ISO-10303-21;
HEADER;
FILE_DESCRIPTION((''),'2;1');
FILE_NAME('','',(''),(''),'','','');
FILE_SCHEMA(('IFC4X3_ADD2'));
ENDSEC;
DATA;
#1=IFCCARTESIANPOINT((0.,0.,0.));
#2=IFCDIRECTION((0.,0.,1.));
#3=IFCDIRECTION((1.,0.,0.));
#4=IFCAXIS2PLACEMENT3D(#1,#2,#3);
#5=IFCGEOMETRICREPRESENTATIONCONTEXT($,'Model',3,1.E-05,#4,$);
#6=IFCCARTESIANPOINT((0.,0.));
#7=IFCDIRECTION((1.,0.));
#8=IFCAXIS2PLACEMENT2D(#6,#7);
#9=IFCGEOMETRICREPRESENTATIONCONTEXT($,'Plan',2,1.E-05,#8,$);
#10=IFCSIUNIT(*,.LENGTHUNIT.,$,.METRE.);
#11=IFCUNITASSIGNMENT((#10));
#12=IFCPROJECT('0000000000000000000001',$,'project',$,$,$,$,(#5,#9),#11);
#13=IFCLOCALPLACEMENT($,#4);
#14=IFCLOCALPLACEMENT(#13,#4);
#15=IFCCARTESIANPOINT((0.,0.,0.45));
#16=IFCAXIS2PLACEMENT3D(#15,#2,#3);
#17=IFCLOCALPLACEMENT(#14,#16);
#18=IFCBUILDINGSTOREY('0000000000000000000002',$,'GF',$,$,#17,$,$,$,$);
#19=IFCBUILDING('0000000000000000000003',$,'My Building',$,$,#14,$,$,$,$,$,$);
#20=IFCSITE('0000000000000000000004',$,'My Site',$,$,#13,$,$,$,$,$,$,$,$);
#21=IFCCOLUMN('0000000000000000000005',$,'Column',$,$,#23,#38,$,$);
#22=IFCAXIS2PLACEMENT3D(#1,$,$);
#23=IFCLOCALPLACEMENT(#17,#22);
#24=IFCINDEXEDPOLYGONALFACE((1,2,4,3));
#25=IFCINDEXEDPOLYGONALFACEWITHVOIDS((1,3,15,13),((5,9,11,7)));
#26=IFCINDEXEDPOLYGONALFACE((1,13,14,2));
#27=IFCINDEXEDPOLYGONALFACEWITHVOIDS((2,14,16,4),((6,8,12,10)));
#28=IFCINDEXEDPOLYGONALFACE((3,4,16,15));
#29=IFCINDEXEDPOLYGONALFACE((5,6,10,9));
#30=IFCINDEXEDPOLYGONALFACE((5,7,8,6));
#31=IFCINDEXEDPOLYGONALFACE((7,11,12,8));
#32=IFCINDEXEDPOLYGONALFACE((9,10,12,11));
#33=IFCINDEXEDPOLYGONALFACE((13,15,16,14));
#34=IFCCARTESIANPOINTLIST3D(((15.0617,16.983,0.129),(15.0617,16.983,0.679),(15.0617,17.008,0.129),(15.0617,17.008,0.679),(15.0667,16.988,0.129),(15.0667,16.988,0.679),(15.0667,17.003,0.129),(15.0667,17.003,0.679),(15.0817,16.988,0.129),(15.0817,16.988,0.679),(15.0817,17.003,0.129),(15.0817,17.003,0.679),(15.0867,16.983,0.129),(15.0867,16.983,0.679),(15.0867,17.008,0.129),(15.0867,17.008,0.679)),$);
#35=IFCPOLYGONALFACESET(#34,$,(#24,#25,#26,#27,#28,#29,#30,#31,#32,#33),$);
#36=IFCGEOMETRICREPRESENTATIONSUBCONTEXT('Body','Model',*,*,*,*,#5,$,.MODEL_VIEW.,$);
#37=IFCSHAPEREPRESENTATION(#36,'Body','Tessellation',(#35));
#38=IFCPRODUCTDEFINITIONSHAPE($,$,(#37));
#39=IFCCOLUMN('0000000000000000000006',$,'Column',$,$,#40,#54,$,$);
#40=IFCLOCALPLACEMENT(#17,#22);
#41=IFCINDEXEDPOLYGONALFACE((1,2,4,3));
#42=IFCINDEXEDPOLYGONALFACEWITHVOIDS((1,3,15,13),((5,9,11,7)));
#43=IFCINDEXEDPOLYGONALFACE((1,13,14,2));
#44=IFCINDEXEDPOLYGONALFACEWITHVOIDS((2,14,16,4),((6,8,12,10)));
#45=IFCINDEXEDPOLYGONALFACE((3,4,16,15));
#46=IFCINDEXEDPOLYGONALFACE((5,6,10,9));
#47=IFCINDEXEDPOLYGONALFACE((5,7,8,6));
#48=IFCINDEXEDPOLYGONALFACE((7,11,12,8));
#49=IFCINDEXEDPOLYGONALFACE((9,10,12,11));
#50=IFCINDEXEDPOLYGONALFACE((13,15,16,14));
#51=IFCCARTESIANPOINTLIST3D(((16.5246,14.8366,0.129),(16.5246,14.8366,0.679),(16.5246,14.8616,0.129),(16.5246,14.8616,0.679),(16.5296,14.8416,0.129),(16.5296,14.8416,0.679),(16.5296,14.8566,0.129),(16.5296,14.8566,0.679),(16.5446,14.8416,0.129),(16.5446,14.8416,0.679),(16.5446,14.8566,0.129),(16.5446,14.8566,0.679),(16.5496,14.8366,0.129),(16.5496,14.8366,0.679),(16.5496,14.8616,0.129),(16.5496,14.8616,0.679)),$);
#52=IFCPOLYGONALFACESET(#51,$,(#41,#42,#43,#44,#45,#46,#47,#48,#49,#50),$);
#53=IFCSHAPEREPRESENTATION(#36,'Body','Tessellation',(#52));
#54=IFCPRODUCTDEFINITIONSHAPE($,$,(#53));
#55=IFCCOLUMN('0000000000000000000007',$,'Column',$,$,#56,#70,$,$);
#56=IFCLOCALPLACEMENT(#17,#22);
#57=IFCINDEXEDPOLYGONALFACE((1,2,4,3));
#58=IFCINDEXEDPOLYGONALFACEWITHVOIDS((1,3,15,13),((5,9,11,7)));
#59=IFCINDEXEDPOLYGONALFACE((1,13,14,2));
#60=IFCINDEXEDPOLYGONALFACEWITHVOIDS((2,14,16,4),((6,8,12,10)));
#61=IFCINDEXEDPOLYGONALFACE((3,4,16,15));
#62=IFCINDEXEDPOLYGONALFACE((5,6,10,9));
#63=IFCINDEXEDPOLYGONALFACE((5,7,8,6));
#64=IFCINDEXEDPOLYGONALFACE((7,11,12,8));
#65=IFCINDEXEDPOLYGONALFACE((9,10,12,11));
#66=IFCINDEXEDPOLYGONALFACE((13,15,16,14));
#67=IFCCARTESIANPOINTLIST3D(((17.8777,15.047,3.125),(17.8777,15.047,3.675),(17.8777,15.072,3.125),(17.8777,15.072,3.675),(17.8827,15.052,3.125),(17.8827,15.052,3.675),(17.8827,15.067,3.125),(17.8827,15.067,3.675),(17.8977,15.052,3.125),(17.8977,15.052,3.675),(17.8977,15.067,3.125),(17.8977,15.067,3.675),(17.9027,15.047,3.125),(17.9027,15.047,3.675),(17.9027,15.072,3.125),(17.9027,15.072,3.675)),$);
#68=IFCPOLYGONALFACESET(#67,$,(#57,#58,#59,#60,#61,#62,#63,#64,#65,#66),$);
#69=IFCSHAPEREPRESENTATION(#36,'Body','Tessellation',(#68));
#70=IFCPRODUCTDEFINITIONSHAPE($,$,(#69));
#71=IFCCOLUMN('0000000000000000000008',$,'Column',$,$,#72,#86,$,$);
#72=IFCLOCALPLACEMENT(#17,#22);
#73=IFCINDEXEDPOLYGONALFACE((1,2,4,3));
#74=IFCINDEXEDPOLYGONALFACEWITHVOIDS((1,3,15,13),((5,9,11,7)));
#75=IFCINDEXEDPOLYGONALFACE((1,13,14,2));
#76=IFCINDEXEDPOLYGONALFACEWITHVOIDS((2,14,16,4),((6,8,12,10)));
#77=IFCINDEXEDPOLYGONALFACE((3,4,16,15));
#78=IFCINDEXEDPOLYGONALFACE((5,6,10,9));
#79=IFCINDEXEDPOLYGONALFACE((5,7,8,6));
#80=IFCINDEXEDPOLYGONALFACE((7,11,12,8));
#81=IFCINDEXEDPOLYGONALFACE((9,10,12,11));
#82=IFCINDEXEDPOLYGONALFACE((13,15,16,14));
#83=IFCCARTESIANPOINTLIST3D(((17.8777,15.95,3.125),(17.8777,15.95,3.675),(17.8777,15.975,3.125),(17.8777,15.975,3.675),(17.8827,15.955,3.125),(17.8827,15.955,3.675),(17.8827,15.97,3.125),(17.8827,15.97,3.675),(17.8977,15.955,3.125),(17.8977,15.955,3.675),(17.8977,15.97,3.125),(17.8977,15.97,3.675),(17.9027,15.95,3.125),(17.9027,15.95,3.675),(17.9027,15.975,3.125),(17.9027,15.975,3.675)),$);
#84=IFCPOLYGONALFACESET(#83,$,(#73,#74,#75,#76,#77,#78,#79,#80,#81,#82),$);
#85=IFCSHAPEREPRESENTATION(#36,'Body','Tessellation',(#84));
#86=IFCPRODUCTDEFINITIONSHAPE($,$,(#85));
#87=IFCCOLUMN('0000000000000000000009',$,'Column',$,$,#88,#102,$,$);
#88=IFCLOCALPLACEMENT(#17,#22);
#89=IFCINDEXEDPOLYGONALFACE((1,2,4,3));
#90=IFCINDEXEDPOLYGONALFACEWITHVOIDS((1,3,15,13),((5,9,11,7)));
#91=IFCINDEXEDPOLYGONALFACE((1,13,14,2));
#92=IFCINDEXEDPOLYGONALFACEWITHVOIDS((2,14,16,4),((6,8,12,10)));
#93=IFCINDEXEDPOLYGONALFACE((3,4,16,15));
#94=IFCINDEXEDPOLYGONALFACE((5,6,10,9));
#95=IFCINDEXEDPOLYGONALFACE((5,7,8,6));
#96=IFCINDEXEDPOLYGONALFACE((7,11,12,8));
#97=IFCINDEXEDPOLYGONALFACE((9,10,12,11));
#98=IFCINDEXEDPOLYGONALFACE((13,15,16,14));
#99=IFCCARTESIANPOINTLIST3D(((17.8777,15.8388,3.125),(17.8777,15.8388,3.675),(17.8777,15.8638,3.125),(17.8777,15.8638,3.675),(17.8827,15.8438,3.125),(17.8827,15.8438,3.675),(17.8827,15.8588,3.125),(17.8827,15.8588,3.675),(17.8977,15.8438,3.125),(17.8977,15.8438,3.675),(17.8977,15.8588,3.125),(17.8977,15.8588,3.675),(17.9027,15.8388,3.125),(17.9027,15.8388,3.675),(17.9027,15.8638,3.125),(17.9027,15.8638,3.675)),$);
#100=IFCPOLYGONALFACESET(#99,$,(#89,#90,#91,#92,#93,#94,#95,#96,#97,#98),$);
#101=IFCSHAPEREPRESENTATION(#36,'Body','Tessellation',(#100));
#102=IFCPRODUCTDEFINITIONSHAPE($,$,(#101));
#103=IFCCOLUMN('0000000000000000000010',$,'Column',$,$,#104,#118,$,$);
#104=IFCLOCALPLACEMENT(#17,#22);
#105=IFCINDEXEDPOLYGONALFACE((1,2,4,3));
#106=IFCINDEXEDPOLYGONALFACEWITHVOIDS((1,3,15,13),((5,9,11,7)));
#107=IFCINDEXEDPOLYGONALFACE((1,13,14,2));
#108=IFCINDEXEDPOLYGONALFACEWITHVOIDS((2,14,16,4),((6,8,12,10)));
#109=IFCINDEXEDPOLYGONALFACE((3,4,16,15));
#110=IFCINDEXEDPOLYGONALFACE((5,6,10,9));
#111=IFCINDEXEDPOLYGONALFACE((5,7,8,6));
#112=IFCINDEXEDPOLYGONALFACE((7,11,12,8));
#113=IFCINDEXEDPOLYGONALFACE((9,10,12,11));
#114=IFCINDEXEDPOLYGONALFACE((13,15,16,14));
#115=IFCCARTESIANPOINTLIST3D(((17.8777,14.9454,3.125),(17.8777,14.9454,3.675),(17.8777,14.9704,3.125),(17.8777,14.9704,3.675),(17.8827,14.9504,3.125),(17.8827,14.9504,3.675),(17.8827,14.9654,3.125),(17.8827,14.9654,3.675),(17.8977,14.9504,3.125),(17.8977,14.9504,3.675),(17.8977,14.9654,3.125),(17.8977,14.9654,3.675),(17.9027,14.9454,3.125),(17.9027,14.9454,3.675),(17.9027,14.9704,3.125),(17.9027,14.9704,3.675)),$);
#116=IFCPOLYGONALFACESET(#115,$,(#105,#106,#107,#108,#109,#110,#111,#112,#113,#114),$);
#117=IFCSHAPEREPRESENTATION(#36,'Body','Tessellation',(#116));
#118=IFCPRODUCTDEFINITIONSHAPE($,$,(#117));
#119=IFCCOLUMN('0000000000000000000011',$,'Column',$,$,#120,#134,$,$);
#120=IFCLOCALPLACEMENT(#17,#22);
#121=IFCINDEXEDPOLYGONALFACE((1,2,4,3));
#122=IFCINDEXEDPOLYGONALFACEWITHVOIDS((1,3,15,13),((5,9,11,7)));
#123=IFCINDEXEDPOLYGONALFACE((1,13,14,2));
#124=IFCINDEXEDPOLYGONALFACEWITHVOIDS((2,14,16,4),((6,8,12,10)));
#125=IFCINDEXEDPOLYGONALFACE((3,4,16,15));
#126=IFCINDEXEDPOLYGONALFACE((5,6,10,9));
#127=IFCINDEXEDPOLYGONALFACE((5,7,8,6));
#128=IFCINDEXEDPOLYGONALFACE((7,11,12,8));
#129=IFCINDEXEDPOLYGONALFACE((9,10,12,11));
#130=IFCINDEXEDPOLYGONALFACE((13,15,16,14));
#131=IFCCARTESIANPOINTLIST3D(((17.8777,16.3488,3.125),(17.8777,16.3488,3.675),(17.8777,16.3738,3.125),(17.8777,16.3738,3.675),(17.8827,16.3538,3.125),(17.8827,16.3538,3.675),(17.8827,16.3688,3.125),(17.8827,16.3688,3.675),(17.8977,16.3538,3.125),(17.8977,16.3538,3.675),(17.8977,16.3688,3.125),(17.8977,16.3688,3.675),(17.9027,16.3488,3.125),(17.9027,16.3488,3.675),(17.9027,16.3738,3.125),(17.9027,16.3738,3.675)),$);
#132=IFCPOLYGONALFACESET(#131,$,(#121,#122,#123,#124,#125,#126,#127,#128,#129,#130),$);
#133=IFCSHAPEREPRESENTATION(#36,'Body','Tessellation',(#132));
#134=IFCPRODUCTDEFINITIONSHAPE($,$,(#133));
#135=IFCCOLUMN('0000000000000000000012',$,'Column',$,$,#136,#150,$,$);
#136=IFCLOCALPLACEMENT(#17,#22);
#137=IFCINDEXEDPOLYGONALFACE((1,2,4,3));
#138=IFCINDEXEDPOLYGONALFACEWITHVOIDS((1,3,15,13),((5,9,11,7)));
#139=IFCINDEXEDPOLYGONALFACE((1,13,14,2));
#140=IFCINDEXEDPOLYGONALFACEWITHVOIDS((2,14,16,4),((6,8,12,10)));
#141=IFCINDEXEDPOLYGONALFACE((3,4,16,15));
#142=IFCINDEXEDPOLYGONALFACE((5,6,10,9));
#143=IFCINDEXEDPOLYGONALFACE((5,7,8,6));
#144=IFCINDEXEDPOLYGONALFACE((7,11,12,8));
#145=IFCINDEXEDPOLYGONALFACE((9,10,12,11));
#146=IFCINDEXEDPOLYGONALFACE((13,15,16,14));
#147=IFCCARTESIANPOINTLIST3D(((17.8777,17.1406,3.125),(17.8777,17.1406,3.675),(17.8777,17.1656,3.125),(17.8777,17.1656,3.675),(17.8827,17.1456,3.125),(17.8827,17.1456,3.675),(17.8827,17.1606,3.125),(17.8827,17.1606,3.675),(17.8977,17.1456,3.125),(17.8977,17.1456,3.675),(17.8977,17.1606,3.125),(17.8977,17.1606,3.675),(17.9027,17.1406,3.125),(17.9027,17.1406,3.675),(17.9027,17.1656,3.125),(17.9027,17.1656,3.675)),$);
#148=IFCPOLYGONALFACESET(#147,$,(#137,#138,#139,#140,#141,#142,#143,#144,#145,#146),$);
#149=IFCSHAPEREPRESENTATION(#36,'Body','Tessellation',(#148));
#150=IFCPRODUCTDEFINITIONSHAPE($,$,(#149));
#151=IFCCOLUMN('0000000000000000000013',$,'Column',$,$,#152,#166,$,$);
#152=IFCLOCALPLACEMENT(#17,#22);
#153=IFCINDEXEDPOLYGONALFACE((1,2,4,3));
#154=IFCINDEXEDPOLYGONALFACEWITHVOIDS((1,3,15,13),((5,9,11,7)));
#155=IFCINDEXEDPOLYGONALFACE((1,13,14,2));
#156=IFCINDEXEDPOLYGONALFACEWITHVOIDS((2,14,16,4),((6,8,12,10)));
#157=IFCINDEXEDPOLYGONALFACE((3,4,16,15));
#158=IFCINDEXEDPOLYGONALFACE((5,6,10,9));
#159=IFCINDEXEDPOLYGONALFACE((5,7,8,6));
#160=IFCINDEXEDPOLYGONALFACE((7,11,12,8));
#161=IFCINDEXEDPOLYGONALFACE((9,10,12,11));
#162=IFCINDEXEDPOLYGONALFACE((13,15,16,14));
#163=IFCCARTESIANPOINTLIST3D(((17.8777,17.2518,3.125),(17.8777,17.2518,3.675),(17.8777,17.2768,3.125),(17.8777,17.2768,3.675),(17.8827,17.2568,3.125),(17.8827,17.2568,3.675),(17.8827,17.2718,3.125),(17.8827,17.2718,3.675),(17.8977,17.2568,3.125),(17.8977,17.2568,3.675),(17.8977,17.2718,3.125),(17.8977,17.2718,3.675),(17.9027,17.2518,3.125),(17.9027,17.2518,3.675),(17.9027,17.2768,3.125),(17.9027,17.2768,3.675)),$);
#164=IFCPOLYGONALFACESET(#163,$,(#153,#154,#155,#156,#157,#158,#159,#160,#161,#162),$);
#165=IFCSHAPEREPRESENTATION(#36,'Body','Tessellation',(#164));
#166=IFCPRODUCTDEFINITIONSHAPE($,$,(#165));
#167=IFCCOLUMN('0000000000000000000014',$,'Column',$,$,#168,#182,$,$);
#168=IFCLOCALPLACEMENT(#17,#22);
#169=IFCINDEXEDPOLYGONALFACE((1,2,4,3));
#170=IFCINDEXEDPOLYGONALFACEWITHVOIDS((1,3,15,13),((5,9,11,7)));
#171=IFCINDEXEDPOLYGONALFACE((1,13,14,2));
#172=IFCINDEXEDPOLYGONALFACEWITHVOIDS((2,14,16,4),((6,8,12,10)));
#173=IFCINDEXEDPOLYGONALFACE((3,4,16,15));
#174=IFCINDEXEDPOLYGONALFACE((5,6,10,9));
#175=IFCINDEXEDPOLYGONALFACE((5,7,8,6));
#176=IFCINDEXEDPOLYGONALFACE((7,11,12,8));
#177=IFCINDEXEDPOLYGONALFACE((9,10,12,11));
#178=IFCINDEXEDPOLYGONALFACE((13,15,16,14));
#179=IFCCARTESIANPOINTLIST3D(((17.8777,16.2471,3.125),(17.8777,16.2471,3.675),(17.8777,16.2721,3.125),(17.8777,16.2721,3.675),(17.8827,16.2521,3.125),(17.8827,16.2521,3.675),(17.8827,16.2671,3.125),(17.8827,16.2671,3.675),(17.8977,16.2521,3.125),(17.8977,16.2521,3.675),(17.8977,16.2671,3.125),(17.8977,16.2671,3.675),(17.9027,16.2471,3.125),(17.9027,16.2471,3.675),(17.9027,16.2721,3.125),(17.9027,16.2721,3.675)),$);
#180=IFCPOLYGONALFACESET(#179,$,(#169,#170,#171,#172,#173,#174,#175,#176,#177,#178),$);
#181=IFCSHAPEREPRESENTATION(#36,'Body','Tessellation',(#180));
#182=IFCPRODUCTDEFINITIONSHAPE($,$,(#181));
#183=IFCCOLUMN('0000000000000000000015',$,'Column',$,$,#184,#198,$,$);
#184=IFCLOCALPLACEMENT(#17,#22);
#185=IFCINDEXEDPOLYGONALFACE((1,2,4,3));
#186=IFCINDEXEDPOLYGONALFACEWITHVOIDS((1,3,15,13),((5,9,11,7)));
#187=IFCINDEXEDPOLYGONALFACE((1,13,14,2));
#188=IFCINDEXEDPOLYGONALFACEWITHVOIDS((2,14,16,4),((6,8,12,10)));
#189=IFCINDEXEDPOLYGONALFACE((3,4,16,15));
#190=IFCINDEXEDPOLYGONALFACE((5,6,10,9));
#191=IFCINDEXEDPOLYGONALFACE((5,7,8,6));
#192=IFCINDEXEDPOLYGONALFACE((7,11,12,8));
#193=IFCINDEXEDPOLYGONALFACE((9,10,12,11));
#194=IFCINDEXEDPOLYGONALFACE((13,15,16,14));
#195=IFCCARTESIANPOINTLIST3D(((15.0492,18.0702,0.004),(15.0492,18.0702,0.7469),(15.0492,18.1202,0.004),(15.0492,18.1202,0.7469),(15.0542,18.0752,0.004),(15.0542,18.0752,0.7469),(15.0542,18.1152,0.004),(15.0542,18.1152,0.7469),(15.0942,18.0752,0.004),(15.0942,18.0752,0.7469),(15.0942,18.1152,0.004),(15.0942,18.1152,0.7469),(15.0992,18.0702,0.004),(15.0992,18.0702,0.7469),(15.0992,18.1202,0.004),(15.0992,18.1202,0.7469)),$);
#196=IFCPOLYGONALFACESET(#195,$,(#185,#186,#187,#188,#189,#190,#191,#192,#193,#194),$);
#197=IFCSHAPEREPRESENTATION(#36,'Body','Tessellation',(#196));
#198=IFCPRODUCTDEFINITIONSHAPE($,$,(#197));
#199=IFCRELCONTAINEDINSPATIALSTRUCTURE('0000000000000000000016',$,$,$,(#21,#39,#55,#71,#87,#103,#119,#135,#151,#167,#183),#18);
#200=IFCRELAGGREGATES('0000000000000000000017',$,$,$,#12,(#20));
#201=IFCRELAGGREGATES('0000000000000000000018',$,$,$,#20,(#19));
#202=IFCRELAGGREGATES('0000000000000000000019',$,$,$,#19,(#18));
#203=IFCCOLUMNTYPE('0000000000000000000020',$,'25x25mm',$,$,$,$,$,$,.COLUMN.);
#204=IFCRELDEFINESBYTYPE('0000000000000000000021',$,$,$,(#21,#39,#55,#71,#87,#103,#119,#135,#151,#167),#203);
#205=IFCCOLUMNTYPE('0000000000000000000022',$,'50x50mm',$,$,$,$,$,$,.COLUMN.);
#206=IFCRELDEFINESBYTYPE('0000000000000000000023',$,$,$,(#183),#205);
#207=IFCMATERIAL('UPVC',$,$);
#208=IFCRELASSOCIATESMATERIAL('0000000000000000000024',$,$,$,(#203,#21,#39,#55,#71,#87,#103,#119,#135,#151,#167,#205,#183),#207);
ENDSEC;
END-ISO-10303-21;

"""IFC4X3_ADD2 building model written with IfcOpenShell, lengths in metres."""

from ifc_helpers import new_model, si_unit, frame, origin_with_axes, origin_2d_with_axis, place, context, subcontext, project, spatial, hollow_rectangle, extrude, material, material_profile, profile_set, profile_usage, type_object, element, save


model = new_model("IFC4X3_ADD2")

# Units and contexts
model_context = context("Model", 3, precision=1e-05, world=origin_with_axes())
plan_context = context("Plan", 2, precision=1e-05, world=origin_2d_with_axis())
body_context_1 = subcontext(model_context, "Body", "Model", "MODEL_VIEW")
ifc_project = project(units=[si_unit("LENGTHUNIT", "METRE")], contexts=[model_context, plan_context])

# Site, building, storey
site_placement = place(None, origin_with_axes())
site = spatial("IfcSite", under=ifc_project, at=site_placement, Name="My Site")
building_placement = place(site_placement, origin_with_axes())
building = spatial("IfcBuilding", under=site, at=building_placement, Name="My Building")
storey_placement = place(building_placement, frame((0.0, 0.0, 0.45), z_axis=(0.0, 0.0, 1.0), x_axis=(1.0, 0.0, 0.0)))
storey = spatial("IfcBuildingStorey", under=building, at=storey_placement, Name="GF")

# Columns
ifc_material_1 = material(Name="UPVC")
ifc_material_profile_1 = material_profile(ifc_material_1, hollow_rectangle(XDim=0.025, YDim=0.025, WallThickness=0.005))
ifc_profile_set_1 = profile_set([ifc_material_profile_1])
column_type_1 = type_object("IfcColumnType", Name="25x25mm", PredefinedType="COLUMN", material=ifc_profile_set_1)
ifc_profile_usage_1 = profile_usage(ifc_profile_set_1)
column_1_placement = place(storey_placement, frame((15.0742, 16.9955, 0.129), z_axis=(0.0, 0.0, 1.0), x_axis=(0.0, -1.0, 0.0)))
element("IfcColumn", 1, at=column_1_placement, inside=storey, type_object=column_type_1, material=ifc_profile_usage_1, Name="Column", context=body_context_1, shape_type="SweptSolid", body=[
    extrude(hollow_rectangle(XDim=0.025, YDim=0.025, WallThickness=0.005), origin_with_axes(), (0.0, 0.0, 1.0), 0.55),
])
ifc_profile_usage_2 = profile_usage(ifc_profile_set_1)
column_2_placement = place(storey_placement, frame((16.5371, 14.8491, 0.129), z_axis=(0.0, 0.0, 1.0), x_axis=(0.0, -1.0, 0.0)))
element("IfcColumn", 2, at=column_2_placement, inside=storey, type_object=column_type_1, material=ifc_profile_usage_2, Name="Column", context=body_context_1, shape_type="SweptSolid", body=[
    extrude(hollow_rectangle(XDim=0.025, YDim=0.025, WallThickness=0.005), origin_with_axes(), (0.0, 0.0, 1.0), 0.55),
])
ifc_profile_usage_3 = profile_usage(ifc_profile_set_1)
column_3_placement = place(storey_placement, frame((17.8902, 15.0595, 3.125), z_axis=(0.0, 0.0, 1.0), x_axis=(0.0, -1.0, 0.0)))
element("IfcColumn", 3, at=column_3_placement, inside=storey, type_object=column_type_1, material=ifc_profile_usage_3, Name="Column", context=body_context_1, shape_type="SweptSolid", body=[
    extrude(hollow_rectangle(XDim=0.025, YDim=0.025, WallThickness=0.005), origin_with_axes(), (0.0, 0.0, 1.0), 0.55),
])
ifc_profile_usage_4 = profile_usage(ifc_profile_set_1)
column_4_placement = place(storey_placement, frame((17.8902, 15.9625, 3.125), z_axis=(0.0, 0.0, 1.0), x_axis=(0.0, -1.0, 0.0)))
element("IfcColumn", 4, at=column_4_placement, inside=storey, type_object=column_type_1, material=ifc_profile_usage_4, Name="Column", context=body_context_1, shape_type="SweptSolid", body=[
    extrude(hollow_rectangle(XDim=0.025, YDim=0.025, WallThickness=0.005), origin_with_axes(), (0.0, 0.0, 1.0), 0.55),
])
ifc_profile_usage_5 = profile_usage(ifc_profile_set_1)
column_5_placement = place(storey_placement, frame((17.8902, 15.8513, 3.125), z_axis=(0.0, 0.0, 1.0), x_axis=(0.0, -1.0, 0.0)))
element("IfcColumn", 5, at=column_5_placement, inside=storey, type_object=column_type_1, material=ifc_profile_usage_5, Name="Column", context=body_context_1, shape_type="SweptSolid", body=[
    extrude(hollow_rectangle(XDim=0.025, YDim=0.025, WallThickness=0.005), origin_with_axes(), (0.0, 0.0, 1.0), 0.55),
])
ifc_profile_usage_6 = profile_usage(ifc_profile_set_1)
column_6_placement = place(storey_placement, frame((17.8902, 14.9579, 3.125), z_axis=(0.0, 0.0, 1.0), x_axis=(0.0, -1.0, 0.0)))
element("IfcColumn", 6, at=column_6_placement, inside=storey, type_object=column_type_1, material=ifc_profile_usage_6, Name="Column", context=body_context_1, shape_type="SweptSolid", body=[
    extrude(hollow_rectangle(XDim=0.025, YDim=0.025, WallThickness=0.005), origin_with_axes(), (0.0, 0.0, 1.0), 0.55),
])
ifc_profile_usage_7 = profile_usage(ifc_profile_set_1)
column_7_placement = place(storey_placement, frame((17.8902, 16.3613, 3.125), z_axis=(0.0, 0.0, 1.0), x_axis=(0.0, -1.0, 0.0)))
element("IfcColumn", 7, at=column_7_placement, inside=storey, type_object=column_type_1, material=ifc_profile_usage_7, Name="Column", context=body_context_1, shape_type="SweptSolid", body=[
    extrude(hollow_rectangle(XDim=0.025, YDim=0.025, WallThickness=0.005), origin_with_axes(), (0.0, 0.0, 1.0), 0.55),
])
ifc_profile_usage_8 = profile_usage(ifc_profile_set_1)
column_8_placement = place(storey_placement, frame((17.8902, 17.1531, 3.125), z_axis=(0.0, 0.0, 1.0), x_axis=(0.0, -1.0, 0.0)))
element("IfcColumn", 8, at=column_8_placement, inside=storey, type_object=column_type_1, material=ifc_profile_usage_8, Name="Column", context=body_context_1, shape_type="SweptSolid", body=[
    extrude(hollow_rectangle(XDim=0.025, YDim=0.025, WallThickness=0.005), origin_with_axes(), (0.0, 0.0, 1.0), 0.55),
])
ifc_profile_usage_9 = profile_usage(ifc_profile_set_1)
column_9_placement = place(storey_placement, frame((17.8902, 17.2643, 3.125), z_axis=(0.0, 0.0, 1.0), x_axis=(0.0, -1.0, 0.0)))
element("IfcColumn", 9, at=column_9_placement, inside=storey, type_object=column_type_1, material=ifc_profile_usage_9, Name="Column", context=body_context_1, shape_type="SweptSolid", body=[
    extrude(hollow_rectangle(XDim=0.025, YDim=0.025, WallThickness=0.005), origin_with_axes(), (0.0, 0.0, 1.0), 0.55),
])
ifc_profile_usage_10 = profile_usage(ifc_profile_set_1)
column_10_placement = place(storey_placement, frame((17.8902, 16.2596, 3.125), z_axis=(0.0, 0.0, 1.0), x_axis=(0.0, -1.0, 0.0)))
element("IfcColumn", 10, at=column_10_placement, inside=storey, type_object=column_type_1, material=ifc_profile_usage_10, Name="Column", context=body_context_1, shape_type="SweptSolid", body=[
    extrude(hollow_rectangle(XDim=0.025, YDim=0.025, WallThickness=0.005), origin_with_axes(), (0.0, 0.0, 1.0), 0.55),
])
ifc_material_profile_2 = material_profile(ifc_material_1, hollow_rectangle(XDim=0.05, YDim=0.05, WallThickness=0.005))
ifc_profile_set_2 = profile_set([ifc_material_profile_2])
ifc_profile_usage_11 = profile_usage(ifc_profile_set_2)
column_type_2 = type_object("IfcColumnType", Name="50x50mm", PredefinedType="COLUMN", material=ifc_profile_set_2)
column_11_placement = place(storey_placement, frame((15.0742, 18.0952, 0.004), z_axis=(0.0, 0.0, 1.0), x_axis=(0.0, -1.0, 0.0)))
element("IfcColumn", 11, at=column_11_placement, inside=storey, type_object=column_type_2, material=ifc_profile_usage_11, Name="Column", context=body_context_1, shape_type="SweptSolid", body=[
    extrude(hollow_rectangle(XDim=0.05, YDim=0.05, WallThickness=0.005), origin_with_axes(), (0.0, 0.0, 1.0), 0.7429),
])

save(model, "model.ifc")
